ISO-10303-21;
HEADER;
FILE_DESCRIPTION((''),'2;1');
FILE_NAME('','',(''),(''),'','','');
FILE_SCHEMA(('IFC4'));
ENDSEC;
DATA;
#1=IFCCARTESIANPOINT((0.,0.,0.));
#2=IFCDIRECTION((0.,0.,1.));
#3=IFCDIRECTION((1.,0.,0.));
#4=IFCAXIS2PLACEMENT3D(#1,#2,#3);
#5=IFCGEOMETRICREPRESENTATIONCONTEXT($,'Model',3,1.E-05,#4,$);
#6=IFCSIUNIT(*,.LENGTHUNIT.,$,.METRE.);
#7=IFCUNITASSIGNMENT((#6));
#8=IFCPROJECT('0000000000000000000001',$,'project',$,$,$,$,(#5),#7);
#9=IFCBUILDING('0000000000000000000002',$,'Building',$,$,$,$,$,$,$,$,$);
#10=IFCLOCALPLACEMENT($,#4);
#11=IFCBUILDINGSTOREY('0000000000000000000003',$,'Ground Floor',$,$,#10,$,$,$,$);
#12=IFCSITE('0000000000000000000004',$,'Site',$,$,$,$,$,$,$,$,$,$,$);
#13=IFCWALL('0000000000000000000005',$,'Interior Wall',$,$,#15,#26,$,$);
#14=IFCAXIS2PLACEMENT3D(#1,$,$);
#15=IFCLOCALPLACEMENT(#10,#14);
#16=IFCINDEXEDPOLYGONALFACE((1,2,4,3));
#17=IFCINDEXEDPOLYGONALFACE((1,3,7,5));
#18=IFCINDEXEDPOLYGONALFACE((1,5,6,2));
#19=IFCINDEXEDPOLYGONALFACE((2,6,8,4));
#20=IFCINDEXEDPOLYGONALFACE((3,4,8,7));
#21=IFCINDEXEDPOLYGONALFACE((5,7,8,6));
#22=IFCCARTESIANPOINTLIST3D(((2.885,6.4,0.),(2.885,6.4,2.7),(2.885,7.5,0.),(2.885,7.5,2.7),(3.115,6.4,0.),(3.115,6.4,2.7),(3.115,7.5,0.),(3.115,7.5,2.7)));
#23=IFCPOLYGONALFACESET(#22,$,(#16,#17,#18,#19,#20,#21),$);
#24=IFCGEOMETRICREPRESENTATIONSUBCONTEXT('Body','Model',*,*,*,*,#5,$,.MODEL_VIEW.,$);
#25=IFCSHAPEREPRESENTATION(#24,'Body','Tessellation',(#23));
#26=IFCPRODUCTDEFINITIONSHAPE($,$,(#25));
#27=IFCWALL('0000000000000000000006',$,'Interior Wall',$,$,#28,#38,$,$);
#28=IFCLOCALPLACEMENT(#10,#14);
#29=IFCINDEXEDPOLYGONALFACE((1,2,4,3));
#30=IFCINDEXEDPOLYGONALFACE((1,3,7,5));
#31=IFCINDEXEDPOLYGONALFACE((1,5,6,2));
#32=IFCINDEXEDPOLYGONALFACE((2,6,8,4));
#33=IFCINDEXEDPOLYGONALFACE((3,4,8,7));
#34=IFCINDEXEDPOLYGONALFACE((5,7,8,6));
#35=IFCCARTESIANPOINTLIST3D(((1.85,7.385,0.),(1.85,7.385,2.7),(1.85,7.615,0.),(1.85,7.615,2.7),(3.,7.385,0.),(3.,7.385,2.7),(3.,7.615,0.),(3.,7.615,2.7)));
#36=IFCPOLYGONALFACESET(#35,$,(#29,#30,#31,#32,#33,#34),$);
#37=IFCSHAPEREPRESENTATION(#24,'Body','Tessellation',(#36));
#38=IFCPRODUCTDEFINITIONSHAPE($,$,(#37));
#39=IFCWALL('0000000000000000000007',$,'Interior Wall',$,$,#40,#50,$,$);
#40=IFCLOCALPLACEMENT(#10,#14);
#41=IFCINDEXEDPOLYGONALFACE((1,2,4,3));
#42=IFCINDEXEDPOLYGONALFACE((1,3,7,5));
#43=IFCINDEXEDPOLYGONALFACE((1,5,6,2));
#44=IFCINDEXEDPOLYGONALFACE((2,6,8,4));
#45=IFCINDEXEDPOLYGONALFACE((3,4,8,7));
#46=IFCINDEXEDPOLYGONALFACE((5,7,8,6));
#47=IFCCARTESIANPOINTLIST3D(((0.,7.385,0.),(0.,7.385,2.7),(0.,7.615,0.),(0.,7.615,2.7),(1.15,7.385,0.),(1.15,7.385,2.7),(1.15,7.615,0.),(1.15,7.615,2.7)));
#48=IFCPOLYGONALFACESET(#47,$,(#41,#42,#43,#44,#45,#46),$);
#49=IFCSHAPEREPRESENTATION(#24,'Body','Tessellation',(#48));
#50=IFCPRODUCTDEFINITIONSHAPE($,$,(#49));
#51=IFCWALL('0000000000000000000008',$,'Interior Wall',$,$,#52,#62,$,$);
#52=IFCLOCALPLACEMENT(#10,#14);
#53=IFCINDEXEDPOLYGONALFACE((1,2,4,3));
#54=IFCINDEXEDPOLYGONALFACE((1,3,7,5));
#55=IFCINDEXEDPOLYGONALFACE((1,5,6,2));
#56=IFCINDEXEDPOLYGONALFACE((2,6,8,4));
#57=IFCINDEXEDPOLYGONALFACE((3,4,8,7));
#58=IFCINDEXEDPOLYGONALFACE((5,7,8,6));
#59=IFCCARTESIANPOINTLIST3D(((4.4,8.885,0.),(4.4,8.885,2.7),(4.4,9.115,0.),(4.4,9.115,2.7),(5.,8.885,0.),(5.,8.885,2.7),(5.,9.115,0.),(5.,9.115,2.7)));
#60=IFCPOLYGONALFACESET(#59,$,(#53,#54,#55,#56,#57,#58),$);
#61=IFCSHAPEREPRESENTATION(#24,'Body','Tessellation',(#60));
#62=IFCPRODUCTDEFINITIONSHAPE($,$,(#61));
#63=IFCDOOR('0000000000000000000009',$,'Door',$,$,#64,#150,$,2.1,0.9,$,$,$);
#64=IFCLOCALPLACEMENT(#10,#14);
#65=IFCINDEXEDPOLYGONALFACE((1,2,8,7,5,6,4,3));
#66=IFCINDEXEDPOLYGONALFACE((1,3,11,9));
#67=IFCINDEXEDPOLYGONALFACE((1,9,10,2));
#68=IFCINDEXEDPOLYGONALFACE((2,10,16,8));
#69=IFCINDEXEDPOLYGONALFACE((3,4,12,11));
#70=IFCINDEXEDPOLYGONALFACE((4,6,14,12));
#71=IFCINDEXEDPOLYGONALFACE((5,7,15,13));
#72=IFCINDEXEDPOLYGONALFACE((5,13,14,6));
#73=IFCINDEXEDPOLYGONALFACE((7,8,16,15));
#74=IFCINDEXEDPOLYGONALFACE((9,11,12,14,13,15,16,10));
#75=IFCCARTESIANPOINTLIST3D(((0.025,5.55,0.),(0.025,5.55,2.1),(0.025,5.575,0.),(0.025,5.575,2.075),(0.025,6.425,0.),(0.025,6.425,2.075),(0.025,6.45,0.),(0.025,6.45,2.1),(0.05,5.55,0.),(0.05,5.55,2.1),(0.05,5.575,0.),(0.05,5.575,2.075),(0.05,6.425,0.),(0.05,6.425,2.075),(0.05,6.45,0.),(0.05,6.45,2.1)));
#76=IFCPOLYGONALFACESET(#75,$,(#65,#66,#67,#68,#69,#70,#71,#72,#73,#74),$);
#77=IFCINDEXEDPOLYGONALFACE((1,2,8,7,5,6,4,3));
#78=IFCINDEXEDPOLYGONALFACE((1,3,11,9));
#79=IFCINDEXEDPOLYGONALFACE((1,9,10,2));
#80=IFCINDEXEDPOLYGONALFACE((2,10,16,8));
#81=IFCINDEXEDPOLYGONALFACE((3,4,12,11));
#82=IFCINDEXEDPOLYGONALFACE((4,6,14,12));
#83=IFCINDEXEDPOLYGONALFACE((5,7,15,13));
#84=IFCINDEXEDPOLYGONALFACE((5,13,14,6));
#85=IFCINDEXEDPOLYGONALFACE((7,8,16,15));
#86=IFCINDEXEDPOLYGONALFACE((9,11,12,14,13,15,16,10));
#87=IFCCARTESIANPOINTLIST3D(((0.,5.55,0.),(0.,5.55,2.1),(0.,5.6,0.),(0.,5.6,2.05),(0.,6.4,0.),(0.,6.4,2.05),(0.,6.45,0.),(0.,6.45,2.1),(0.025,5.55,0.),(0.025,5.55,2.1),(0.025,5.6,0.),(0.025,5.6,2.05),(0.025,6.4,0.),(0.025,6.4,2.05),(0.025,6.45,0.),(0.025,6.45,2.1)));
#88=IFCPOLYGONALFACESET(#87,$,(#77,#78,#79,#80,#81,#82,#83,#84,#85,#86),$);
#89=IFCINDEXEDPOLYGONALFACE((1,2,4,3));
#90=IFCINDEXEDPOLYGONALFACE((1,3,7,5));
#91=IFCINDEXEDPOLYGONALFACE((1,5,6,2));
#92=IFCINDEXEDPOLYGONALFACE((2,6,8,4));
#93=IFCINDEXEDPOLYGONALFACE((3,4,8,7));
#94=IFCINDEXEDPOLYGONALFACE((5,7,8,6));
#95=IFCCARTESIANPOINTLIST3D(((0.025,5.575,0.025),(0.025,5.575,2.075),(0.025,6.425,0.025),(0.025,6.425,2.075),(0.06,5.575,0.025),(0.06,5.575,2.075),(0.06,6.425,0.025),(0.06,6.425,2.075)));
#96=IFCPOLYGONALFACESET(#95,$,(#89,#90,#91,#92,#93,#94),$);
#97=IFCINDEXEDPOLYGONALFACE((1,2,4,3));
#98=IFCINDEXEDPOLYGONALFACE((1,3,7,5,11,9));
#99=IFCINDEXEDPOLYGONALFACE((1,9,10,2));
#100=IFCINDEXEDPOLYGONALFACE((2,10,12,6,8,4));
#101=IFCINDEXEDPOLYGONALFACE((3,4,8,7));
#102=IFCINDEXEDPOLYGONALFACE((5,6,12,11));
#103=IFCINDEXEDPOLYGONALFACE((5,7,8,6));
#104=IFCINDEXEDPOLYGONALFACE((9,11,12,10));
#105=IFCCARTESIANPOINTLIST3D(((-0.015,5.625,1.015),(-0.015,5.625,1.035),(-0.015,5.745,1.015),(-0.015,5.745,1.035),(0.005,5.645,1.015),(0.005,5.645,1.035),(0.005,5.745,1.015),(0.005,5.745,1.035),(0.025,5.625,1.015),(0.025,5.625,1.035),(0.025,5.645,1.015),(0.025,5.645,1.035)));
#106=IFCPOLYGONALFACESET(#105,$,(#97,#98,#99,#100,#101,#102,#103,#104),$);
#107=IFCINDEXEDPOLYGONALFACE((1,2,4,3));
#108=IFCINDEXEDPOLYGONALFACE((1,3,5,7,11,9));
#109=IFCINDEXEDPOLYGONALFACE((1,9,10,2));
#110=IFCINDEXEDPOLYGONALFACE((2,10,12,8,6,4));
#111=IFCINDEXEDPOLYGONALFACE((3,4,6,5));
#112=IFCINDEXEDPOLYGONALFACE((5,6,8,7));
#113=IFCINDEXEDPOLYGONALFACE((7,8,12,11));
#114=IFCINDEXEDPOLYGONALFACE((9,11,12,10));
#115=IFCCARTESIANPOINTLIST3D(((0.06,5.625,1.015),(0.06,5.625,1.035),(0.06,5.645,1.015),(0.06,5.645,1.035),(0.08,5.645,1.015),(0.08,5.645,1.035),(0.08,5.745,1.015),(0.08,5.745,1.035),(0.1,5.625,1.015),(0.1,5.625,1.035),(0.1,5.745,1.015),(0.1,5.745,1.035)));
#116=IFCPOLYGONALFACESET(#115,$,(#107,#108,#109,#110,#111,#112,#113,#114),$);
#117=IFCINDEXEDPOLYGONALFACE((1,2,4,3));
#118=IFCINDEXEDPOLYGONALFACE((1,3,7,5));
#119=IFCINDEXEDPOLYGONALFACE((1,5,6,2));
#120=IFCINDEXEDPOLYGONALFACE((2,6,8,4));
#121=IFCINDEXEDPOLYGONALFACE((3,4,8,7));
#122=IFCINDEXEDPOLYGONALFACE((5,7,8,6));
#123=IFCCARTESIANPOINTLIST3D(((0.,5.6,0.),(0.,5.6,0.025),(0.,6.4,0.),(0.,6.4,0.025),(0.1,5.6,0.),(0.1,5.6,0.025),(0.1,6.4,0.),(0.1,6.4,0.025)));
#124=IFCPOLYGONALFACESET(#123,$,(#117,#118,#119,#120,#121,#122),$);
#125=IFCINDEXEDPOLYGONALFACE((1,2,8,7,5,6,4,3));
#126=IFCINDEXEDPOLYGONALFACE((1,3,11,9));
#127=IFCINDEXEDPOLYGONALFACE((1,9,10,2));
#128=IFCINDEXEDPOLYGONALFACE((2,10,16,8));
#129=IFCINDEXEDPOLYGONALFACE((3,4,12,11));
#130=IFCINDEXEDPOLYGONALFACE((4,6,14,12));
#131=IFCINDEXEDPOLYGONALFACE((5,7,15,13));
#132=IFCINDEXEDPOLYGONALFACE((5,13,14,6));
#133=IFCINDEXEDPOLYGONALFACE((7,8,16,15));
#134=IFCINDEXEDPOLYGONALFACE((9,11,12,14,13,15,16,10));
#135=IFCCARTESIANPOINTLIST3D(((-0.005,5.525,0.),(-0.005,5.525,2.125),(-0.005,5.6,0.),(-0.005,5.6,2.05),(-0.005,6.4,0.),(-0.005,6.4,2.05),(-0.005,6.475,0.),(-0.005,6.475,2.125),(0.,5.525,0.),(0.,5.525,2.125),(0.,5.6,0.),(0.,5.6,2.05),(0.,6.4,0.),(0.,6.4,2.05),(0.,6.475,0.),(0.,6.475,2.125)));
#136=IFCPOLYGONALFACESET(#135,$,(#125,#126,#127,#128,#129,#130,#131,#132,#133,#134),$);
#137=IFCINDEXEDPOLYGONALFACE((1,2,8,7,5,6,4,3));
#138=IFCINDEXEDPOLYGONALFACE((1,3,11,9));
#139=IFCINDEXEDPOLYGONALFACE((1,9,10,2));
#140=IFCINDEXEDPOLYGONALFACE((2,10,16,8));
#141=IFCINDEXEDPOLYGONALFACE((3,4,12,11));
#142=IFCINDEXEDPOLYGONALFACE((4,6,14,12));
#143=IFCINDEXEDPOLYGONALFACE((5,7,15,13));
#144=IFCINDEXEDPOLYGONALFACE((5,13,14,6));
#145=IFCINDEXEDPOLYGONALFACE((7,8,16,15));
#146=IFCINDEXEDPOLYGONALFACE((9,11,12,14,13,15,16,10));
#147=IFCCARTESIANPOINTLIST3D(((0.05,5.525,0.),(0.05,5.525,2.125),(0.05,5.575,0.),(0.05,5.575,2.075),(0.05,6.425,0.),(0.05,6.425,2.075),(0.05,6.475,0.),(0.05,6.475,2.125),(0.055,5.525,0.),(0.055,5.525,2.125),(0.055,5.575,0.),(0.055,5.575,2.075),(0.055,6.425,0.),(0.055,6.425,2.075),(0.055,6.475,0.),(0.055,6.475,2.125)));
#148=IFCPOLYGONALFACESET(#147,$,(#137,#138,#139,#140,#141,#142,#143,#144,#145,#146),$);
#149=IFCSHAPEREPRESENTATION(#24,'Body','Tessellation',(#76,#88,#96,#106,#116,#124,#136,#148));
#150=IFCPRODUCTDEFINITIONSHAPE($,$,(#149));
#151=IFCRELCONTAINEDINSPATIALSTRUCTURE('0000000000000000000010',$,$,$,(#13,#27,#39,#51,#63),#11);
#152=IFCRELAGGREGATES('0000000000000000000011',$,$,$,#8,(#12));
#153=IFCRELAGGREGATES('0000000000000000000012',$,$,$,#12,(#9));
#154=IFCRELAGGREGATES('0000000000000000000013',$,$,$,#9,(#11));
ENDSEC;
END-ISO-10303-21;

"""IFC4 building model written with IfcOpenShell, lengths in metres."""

from ifc_helpers import new_model, si_unit, frame, origin_with_axes, place, context, subcontext, project, spatial, line, indexed_curve, outline, extrude, element, save


model = new_model("IFC4")

# Units and contexts
model_context = context("Model", 3, precision=1e-05, world=origin_with_axes())
body_context = subcontext(model_context, "Body", "Model", "MODEL_VIEW")
ifc_project = project(units=[si_unit("LENGTHUNIT", "METRE")], contexts=[model_context])

# Site, building, storey
site = spatial("IfcSite", under=ifc_project, Name="Site")
building = spatial("IfcBuilding", under=site, Name="Building")
storey_placement = place(None, origin_with_axes())
storey = spatial("IfcBuildingStorey", under=building, at=storey_placement, Name="Ground Floor")

# Walls
for number, where, z_axis, x_axis, name in (
    (1, (3.0, 6.4, 0.0), (0.0, 0.0, 1.0), (0.0, 1.0, 0.0), "Interior Wall"),
):
    element("IfcWall", number, at=place(storey_placement, frame(where, z_axis=z_axis, x_axis=x_axis)), inside=storey, Name=name, context=body_context, shape_type="SweptSolid", body=[
        extrude(outline(indexed_curve([(0.0, 0.0), (0.0, 0.23), (1.1, 0.23), (1.1, 0.0), (0.0, 0.0)], self_intersect=False)), frame((0.0, -0.115, 0.0), z_axis=(0.0, 0.0, 1.0), x_axis=(1.0, 0.0, 0.0)), (0.0, 0.0, 1.0), 2.7),
    ])
for number, where, z_axis, x_axis, name in (
    (2, (3.0, 7.5, 0.0), (0.0, 0.0, 1.0), (-1.0, 0.0, 0.0), "Interior Wall"),
    (3, (1.15, 7.5, 0.0), (0.0, 0.0, 1.0), (-1.0, 0.0, 0.0), "Interior Wall"),
):
    element("IfcWall", number, at=place(storey_placement, frame(where, z_axis=z_axis, x_axis=x_axis)), inside=storey, Name=name, context=body_context, shape_type="SweptSolid", body=[
        extrude(outline(indexed_curve([(0.0, 0.0), (0.0, 0.23), (1.15, 0.23), (1.15, 0.0), (0.0, 0.0)], self_intersect=False)), frame((0.0, -0.115, 0.0), z_axis=(0.0, 0.0, 1.0), x_axis=(1.0, 0.0, 0.0)), (0.0, 0.0, 1.0), 2.7),
    ])
wall_1_placement = place(storey_placement, frame((5.0, 9.0, 0.0), z_axis=(0.0, 0.0, 1.0), x_axis=(-1.0, 0.0, 0.0)))
element("IfcWall", 4, at=wall_1_placement, inside=storey, Name="Interior Wall", context=body_context, shape_type="SweptSolid", body=[
    extrude(outline(indexed_curve([(0.0, 0.0), (0.0, 0.23), (0.6, 0.23), (0.6, 0.0), (0.0, 0.0)], self_intersect=False)), frame((0.0, -0.115, 0.0), z_axis=(0.0, 0.0, 1.0), x_axis=(1.0, 0.0, 0.0)), (0.0, 0.0, 1.0), 2.7),
])

# Door
door_1_placement = place(storey_placement, frame((0.0, 6.45, 0.0), z_axis=(0.0, 0.0, 1.0), x_axis=(0.0, -1.0, 0.0)))
element("IfcDoor", 5, at=door_1_placement, inside=storey, Name="Door", OverallHeight=2.1, OverallWidth=0.9, context=body_context, shape_type="SweptSolid", body=[
    extrude(outline(indexed_curve([(0.0, 0.0), (0.0, 2.1), (0.9, 2.1), (0.9, 0.0), (0.875, 0.0), (0.875, 2.075), (0.025, 2.075), (0.025, 0.0)], segments=[line(1, 2, 3, 4, 5, 6, 7, 8, 1)])), frame((0.0, 0.025, 0.0), z_axis=(0.0, -1.0, 0.0), x_axis=(1.0, 0.0, 0.0)), (0.0, 0.0, -1.0), 0.025),
    extrude(outline(indexed_curve([(0.0, 0.0), (0.0, 2.1), (0.9, 2.1), (0.9, 0.0), (0.85, 0.0), (0.85, 2.05), (0.05, 2.05), (0.05, 0.0)], segments=[line(1, 2, 3, 4, 5, 6, 7, 8, 1)])), frame((0.0, 0.0, 0.0), z_axis=(0.0, -1.0, 0.0), x_axis=(1.0, 0.0, 0.0)), (0.0, 0.0, -1.0), 0.025),
    extrude(outline(indexed_curve([(0.0, 0.0), (0.85, 0.0), (0.85, 0.035), (0.0, 0.035)], segments=[line(1, 2, 3, 4, 1)])), frame((0.025, 0.025, 0.025), z_axis=(0.0, 0.0, 1.0), x_axis=(1.0, 0.0, 0.0)), (0.0, 0.0, 1.0), 2.05),
    extrude(outline(indexed_curve([(0.0, 0.0), (0.0, -0.04), (-0.12, -0.04), (-0.12, -0.02), (-0.02, -0.02), (-0.02, 0.0)], segments=[line(1, 2, 3, 4, 5, 6, 1)])), frame((0.825, 0.025, 1.015), z_axis=(0.0, 0.0, 1.0), x_axis=(1.0, 0.0, 0.0)), (0.0, 0.0, 1.0), 0.02),
    extrude(outline(indexed_curve([(0.0, 0.0), (0.0, 0.04), (-0.12, 0.04), (-0.12, 0.02), (-0.02, 0.02), (-0.02, 0.0)], segments=[line(1, 2, 3, 4, 5, 6, 1)])), frame((0.825, 0.06, 1.015), z_axis=(0.0, 0.0, 1.0), x_axis=(1.0, 0.0, 0.0)), (0.0, 0.0, 1.0), 0.02),
    extrude(outline(indexed_curve([(0.0, 0.0), (0.8, 0.0), (0.8, 0.1), (0.0, 0.1)], segments=[line(1, 2, 3, 4, 1)])), frame((0.05, 0.0, 0.0), z_axis=(0.0, 0.0, 1.0), x_axis=(1.0, 0.0, 0.0)), (0.0, 0.0, 1.0), 0.025),
    extrude(outline(indexed_curve([(0.0, 0.0), (0.0, 2.125), (0.95, 2.125), (0.95, 0.0), (0.875, 0.0), (0.875, 2.05), (0.075, 2.05), (0.075, 0.0)], segments=[line(1, 2, 3, 4, 5, 6, 7, 8, 1)])), frame((-0.025, -0.005, 0.0), z_axis=(0.0, -1.0, 0.0), x_axis=(1.0, 0.0, 0.0)), (0.0, 0.0, -1.0), 0.005),
    extrude(outline(indexed_curve([(0.0, 0.0), (0.0, 2.125), (0.95, 2.125), (0.95, 0.0), (0.9, 0.0), (0.9, 2.075), (0.05, 2.075), (0.05, 0.0)], segments=[line(1, 2, 3, 4, 5, 6, 7, 8, 1)])), frame((-0.025, 0.05, 0.0), z_axis=(0.0, -1.0, 0.0), x_axis=(1.0, 0.0, 0.0)), (0.0, 0.0, -1.0), 0.005),
])

save(model, "model.ifc")
